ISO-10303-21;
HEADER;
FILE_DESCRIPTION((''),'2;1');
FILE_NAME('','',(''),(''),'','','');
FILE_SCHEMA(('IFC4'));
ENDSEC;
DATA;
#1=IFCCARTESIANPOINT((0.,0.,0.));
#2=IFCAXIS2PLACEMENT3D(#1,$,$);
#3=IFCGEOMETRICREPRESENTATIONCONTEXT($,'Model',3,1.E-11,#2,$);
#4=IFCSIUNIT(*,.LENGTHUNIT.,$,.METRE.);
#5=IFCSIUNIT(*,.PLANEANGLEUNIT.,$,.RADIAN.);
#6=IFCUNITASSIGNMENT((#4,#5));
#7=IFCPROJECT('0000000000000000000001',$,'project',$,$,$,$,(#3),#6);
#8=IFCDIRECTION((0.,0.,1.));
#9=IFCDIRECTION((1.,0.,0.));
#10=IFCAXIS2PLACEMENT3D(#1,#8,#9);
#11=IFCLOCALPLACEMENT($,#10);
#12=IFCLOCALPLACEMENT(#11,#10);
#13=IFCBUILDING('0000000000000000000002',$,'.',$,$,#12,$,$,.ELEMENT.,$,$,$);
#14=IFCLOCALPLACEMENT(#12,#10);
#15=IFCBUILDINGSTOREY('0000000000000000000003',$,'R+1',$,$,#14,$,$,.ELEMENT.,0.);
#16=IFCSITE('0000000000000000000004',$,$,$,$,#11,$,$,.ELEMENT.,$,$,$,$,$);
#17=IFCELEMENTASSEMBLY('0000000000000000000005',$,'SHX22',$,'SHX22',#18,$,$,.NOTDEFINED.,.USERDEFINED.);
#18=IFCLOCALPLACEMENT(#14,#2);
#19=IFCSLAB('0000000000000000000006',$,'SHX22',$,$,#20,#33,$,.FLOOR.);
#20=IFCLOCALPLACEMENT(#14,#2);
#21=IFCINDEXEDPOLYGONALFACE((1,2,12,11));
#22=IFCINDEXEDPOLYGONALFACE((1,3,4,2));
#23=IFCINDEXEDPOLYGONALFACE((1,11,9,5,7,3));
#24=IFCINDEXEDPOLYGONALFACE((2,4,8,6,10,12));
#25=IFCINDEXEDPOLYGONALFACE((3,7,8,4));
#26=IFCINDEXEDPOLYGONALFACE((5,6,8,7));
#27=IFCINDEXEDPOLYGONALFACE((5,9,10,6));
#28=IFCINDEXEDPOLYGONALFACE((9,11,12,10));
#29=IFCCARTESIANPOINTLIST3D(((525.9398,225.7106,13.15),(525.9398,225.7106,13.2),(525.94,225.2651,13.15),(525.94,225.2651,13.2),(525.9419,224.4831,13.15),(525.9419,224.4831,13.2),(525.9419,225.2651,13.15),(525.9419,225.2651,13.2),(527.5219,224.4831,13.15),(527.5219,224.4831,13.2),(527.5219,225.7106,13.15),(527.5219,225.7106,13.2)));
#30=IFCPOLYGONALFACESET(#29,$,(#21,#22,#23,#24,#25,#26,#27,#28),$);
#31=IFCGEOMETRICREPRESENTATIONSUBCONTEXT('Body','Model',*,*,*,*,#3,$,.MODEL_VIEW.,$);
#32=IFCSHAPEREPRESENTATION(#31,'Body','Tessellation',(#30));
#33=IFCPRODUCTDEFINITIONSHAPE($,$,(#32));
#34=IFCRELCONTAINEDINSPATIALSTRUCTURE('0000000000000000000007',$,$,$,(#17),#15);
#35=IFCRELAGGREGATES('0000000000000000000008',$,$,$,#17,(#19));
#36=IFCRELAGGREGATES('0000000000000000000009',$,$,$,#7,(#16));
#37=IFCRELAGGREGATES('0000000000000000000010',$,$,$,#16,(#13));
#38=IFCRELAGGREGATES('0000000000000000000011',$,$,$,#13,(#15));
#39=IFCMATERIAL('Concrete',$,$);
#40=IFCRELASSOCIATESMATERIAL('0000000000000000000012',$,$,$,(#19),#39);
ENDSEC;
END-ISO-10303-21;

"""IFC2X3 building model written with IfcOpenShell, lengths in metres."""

from ifc_helpers import new_model, si_unit, frame, origin, origin_with_axes, place, context, subcontext, project, spatial, polyline, outline, extrude, material, element, aggregate, save


model = new_model("IFC2X3")

# Units and contexts
model_context = context("Model", 3, precision=1e-11, world=origin())
body_context = subcontext(model_context, "Body", "Model", "MODEL_VIEW")
ifc_project = project(units=[si_unit("LENGTHUNIT", "METRE"), si_unit("PLANEANGLEUNIT", "RADIAN")], contexts=[model_context])

# Site, building, storey
site_placement = place(None, origin_with_axes())
site = spatial("IfcSite", under=ifc_project, at=site_placement, CompositionType="ELEMENT")
building_placement = place(site_placement, origin_with_axes())
building = spatial("IfcBuilding", under=site, at=building_placement, Name=".", CompositionType="ELEMENT")
storey_placement = place(building_placement, origin_with_axes())
storey = spatial("IfcBuildingStorey", under=building, at=storey_placement, Name="R+1", CompositionType="ELEMENT", Elevation=0.0)

# Shared definitions
ifc_material = material(Name="Concrete")

# Element assembly, slab
assembly_1_placement = place(storey_placement, origin_with_axes())
assembly_1 = element("IfcElementAssembly", 1, at=assembly_1_placement, inside=storey, Name="SHX22", ObjectType="SHX22", AssemblyPlace="NOTDEFINED", PredefinedType="USERDEFINED")
slab_1_placement = place(assembly_1_placement, frame((525.9398, 224.4831, 13.15), z_axis=(0.0, 0.0, 1.0), x_axis=(1.0, 0.0, 0.0)))
slab_1 = element("IfcSlab", 2, at=slab_1_placement, material=ifc_material, Name="SHX22", PredefinedType="FLOOR", context=body_context, shape_type="SweptSolid", body=[
    extrude(outline(polyline([(0.0, -0.0022), (0.0, -1.5822), (1.2275, -1.5822), (1.2275, 0.0), (0.7821, -0.0003), (0.7821, -0.0022), (0.0, -0.0022)])), frame((0.0, 0.0, 0.0), z_axis=(0.0, 0.0, 1.0), x_axis=(0.0, 1.0, 0.0)), (0.0, 0.0, 1.0), 0.05),
])

aggregate(assembly_1, [slab_1])

save(model, "model.ifc")
